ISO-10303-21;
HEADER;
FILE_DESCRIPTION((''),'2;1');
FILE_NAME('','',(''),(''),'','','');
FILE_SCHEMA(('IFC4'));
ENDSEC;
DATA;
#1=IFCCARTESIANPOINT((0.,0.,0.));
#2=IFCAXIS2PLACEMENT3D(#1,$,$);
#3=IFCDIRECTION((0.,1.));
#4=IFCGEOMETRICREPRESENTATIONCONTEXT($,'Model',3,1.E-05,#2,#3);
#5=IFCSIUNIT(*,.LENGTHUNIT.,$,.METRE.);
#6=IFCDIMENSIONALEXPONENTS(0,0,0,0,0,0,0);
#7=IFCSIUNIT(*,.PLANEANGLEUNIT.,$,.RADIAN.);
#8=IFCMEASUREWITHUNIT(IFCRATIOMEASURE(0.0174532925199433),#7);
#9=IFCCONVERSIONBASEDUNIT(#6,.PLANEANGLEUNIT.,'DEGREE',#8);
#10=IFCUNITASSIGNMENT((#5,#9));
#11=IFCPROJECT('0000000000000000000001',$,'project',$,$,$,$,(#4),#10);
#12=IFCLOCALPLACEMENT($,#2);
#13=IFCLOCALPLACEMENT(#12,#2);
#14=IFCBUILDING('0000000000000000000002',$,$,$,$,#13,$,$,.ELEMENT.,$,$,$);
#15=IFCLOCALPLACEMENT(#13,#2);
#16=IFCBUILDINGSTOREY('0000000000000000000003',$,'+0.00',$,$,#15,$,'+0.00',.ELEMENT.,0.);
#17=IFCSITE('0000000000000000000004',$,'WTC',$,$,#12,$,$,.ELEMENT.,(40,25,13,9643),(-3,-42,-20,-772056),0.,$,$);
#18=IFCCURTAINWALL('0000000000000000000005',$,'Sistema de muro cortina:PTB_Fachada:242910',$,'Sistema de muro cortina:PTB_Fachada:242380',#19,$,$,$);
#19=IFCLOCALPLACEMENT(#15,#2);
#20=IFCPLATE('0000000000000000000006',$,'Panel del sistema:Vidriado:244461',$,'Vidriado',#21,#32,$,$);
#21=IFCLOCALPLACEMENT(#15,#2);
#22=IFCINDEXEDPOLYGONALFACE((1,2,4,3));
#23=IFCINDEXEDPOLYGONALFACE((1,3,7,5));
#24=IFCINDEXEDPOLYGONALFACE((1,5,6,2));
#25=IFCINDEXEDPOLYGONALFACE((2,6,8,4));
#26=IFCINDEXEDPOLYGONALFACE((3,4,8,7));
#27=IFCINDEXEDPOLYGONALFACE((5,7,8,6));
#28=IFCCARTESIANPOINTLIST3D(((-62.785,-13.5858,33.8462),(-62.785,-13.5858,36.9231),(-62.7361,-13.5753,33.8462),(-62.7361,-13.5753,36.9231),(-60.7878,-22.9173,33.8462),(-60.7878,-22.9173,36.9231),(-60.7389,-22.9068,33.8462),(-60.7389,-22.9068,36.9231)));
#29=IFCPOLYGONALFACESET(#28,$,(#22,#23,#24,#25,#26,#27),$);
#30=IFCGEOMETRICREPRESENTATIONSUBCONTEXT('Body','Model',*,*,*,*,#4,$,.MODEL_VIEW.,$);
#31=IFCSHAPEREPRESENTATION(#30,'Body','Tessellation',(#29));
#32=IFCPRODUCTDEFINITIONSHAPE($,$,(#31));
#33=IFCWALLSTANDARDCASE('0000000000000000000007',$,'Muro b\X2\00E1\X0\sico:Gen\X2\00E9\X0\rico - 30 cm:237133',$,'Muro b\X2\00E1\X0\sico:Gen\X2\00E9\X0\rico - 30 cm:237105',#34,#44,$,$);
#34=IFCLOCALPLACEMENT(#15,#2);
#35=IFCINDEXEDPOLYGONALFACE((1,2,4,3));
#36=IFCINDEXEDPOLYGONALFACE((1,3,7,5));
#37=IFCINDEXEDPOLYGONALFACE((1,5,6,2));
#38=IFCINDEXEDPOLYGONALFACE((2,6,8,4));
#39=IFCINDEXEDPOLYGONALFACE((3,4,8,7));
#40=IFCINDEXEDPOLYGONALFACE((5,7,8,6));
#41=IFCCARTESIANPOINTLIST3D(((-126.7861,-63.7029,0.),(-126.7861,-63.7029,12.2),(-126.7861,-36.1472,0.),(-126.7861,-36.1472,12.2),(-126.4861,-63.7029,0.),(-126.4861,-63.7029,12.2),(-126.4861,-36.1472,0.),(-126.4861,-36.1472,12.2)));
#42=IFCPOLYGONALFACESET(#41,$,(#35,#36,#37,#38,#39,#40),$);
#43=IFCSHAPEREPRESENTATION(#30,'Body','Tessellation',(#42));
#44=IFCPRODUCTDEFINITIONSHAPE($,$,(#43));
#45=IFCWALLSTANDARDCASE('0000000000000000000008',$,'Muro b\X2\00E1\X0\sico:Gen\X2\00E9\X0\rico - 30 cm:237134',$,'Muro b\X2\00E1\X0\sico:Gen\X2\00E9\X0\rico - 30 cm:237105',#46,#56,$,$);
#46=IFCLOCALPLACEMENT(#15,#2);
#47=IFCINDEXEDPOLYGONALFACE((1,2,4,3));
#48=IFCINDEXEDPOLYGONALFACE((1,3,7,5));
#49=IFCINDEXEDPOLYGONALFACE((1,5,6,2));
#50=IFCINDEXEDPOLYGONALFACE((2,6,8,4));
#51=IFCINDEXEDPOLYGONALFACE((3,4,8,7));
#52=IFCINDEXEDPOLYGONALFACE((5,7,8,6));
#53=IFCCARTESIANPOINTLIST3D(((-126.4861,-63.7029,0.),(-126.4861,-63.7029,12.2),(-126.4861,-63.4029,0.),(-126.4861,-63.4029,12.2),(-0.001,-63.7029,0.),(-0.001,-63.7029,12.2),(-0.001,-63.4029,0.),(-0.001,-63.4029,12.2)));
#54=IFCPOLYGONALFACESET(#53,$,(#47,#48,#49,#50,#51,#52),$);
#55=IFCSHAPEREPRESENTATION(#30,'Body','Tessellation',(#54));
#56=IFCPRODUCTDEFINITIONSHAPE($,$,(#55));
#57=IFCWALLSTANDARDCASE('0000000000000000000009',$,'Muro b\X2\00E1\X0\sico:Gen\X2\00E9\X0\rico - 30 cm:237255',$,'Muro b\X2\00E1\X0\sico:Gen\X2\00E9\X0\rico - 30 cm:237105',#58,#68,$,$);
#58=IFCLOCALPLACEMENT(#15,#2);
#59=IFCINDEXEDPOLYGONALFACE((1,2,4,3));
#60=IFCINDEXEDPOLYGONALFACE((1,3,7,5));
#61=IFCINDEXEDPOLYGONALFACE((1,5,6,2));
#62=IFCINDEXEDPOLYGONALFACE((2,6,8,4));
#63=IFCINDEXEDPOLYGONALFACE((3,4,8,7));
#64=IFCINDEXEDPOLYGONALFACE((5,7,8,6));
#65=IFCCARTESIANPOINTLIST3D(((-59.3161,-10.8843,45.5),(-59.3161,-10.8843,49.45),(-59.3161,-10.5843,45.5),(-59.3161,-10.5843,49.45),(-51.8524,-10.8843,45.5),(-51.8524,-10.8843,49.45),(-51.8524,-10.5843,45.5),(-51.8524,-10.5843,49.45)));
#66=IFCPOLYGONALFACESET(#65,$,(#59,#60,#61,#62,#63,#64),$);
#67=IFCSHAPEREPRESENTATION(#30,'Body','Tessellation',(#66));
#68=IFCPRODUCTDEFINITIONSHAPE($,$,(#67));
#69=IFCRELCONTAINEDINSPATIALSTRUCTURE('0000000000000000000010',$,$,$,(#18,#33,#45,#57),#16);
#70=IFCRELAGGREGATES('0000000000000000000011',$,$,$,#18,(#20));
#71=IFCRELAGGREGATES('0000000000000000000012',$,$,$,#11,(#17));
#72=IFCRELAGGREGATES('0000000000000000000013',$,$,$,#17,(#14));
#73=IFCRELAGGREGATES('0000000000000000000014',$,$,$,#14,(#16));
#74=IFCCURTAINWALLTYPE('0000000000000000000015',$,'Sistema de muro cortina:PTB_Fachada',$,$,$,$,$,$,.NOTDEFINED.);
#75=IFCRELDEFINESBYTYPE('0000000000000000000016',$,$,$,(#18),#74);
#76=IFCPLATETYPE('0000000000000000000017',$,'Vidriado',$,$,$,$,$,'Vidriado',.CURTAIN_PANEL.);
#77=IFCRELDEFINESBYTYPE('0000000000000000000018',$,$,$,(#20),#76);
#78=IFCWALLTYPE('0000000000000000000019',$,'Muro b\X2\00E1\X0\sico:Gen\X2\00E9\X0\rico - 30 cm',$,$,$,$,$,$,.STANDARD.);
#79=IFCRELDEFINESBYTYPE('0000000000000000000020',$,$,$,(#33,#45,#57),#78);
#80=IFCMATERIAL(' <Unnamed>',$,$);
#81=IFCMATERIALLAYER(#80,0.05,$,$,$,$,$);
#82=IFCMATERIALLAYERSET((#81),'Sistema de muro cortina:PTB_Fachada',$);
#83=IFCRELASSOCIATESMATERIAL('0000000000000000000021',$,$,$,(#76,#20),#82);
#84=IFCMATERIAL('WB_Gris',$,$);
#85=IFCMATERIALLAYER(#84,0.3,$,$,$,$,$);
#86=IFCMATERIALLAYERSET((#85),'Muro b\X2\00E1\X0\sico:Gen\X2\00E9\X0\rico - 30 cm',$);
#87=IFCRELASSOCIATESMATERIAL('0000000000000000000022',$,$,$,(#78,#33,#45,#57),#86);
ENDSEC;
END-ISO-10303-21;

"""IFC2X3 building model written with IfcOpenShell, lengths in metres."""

from ifc_helpers import new_model, entity, si_unit, converted_unit, direction, frame, frame_2d, origin, origin_2d_with_axis, place, context, subcontext, project, spatial, polyline, rectangle, extrude, clip, bounded_halfspace, source, transform, mapped, material, layer, layer_set, layer_usage, type_object, type_shapes, element, aggregate, save


model = new_model("IFC2X3")

# Units and contexts
model_context = context("Model", 3, precision=1e-05, world=origin(), true_north=direction((0.0, 1.0)))
body_context = subcontext(model_context, "Body", "Model", "MODEL_VIEW")
ifc_project = project(units=[si_unit("LENGTHUNIT", "METRE"), converted_unit("PLANEANGLEUNIT", "DEGREE", entity("IfcRatioMeasure", 0.0174532925199433), si_unit("PLANEANGLEUNIT", "RADIAN"), dimensions=[0, 0, 0, 0, 0, 0, 0])], contexts=[model_context])

# Site, building, storey
site_placement = place(None, origin())
site = spatial("IfcSite", under=ifc_project, at=site_placement, Name="WTC", CompositionType="ELEMENT", RefLatitude=(40, 25, 13, 9643), RefLongitude=(-3, -42, -20, -772056), RefElevation=0.0)
building_placement = place(site_placement, origin())
building = spatial("IfcBuilding", under=site, at=building_placement, CompositionType="ELEMENT")
storey_placement = place(building_placement, origin())
storey = spatial("IfcBuildingStorey", under=building, at=storey_placement, Name="+0.00", LongName="+0.00", CompositionType="ELEMENT", Elevation=0.0)

# Curtain wall, plate
curtain_wall_type = type_object("IfcCurtainWallType", Name="Sistema de muro cortina:PTB_Fachada", PredefinedType="NOTDEFINED")
curtain_wall_placement = place(storey_placement, origin())
curtain_wall = element("IfcCurtainWall", 1, at=curtain_wall_placement, inside=storey, type_object=curtain_wall_type, Name="Sistema de muro cortina:PTB_Fachada:242910", ObjectType="Sistema de muro cortina:PTB_Fachada:242380")
ifc_material_1 = material(Name=" <Unnamed>")
ifc_layer_1 = layer(ifc_material_1, 0.05)
ifc_layer_set_1 = layer_set([ifc_layer_1], Name="Sistema de muro cortina:PTB_Fachada")
plate_type_1 = type_object("IfcPlateType", Name="Vidriado", ElementType="Vidriado", PredefinedType="CURTAIN_PANEL", material=ifc_layer_set_1)
shared_shape_1 = source(origin(), body_context, "Body", "SweptSolid", [
    extrude(rectangle(XDim=0.05, YDim=9.5428, at=origin_2d_with_axis()), frame((0.0, 0.0, 0.0), z_axis=(0.0, 0.0, 1.0), x_axis=(0.0, 1.0, 0.0)), (0.0, 0.0, 1.0), 3.0769),
])
type_shapes(plate_type_1, [shared_shape_1])
ifc_layer_usage_1 = layer_usage(ifc_layer_set_1, "AXIS3", "POSITIVE", 0.0)
plate_1_placement = place(curtain_wall_placement, frame((-61.762, -18.2463, 33.8462), z_axis=(0.0, 0.0, 1.0), x_axis=(0.209296, -0.977852, 0.0)))
plate_1 = element("IfcPlate", 2, at=plate_1_placement, type_object=plate_type_1, material=ifc_layer_usage_1, Name="Panel del sistema:Vidriado:244461", ObjectType="Vidriado", context=body_context, shape_type="MappedRepresentation", body=[
    mapped(shared_shape_1, transform((0.0, 0.0, 0.0), scale=1.0)),
])
aggregate(curtain_wall, [plate_1])

# Walls
ifc_material_2 = material(Name="WB_Gris")
ifc_layer_2 = layer(ifc_material_2, 0.3)
ifc_layer_set_2 = layer_set([ifc_layer_2], Name="Muro básico:Genérico - 30 cm")
ifc_layer_usage_2 = layer_usage(ifc_layer_set_2, "AXIS2", "POSITIVE", -0.15)
wall_type = type_object("IfcWallType", Name="Muro básico:Genérico - 30 cm", PredefinedType="STANDARD", material=ifc_layer_set_2)
wall_1_placement = place(storey_placement, frame((-126.6361, -36.1472, 0.0), z_axis=(0.0, 0.0, 1.0), x_axis=(0.0, -1.0, 0.0)))
element("IfcWallStandardCase", 3, at=wall_1_placement, inside=storey, type_object=wall_type, material=ifc_layer_usage_2, Name="Muro básico:Genérico - 30 cm:237133", ObjectType="Muro básico:Genérico - 30 cm:237105", context=body_context, shape_type="Clipping", body=[
    clip(extrude(rectangle(XDim=27.5557, YDim=0.3, at=frame_2d((13.7778, 0.0), x_axis=(-1.0, 0.0))), origin(), (0.0, 0.0, 1.0), 12.2), bounded_halfspace(frame((0.0, -0.15, 12.2)), False, frame((0.0, -0.15, 12.2)), polyline([(0.0, 0.0), (27.5557, 0.0), (27.5557, 0.3), (0.0, 0.3), (0.0, 0.0)]))),
])
ifc_layer_usage_3 = layer_usage(ifc_layer_set_2, "AXIS2", "POSITIVE", -0.15)
wall_2_placement = place(storey_placement, frame((-126.4861, -63.5529, 0.0)))
element("IfcWallStandardCase", 4, at=wall_2_placement, inside=storey, type_object=wall_type, material=ifc_layer_usage_3, Name="Muro básico:Genérico - 30 cm:237134", ObjectType="Muro básico:Genérico - 30 cm:237105", context=body_context, shape_type="Clipping", body=[
    clip(extrude(rectangle(XDim=126.4851, YDim=0.3, at=frame_2d((63.2426, 0.0), x_axis=(-1.0, 0.0))), origin(), (0.0, 0.0, 1.0), 12.2), bounded_halfspace(frame((0.0, -0.15, 12.2), z_axis=(0.0, 0.0, 1.0), x_axis=(0.0, -1.0, 0.0)), False, frame((0.0, -0.15, 12.2), z_axis=(0.0, 0.0, 1.0), x_axis=(0.0, -1.0, 0.0)), polyline([(0.0, 0.0), (0.0, 126.4851), (-0.3, 126.4851), (-0.3, 0.0), (0.0, 0.0)]))),
])
ifc_layer_usage_4 = layer_usage(ifc_layer_set_2, "AXIS2", "NEGATIVE", 0.15)
wall_3_placement = place(storey_placement, frame((-59.3161, -10.7343, 45.5)))
element("IfcWallStandardCase", 5, at=wall_3_placement, inside=storey, type_object=wall_type, material=ifc_layer_usage_4, Name="Muro básico:Genérico - 30 cm:237255", ObjectType="Muro básico:Genérico - 30 cm:237105", context=body_context, shape_type="Clipping", body=[
    clip(extrude(rectangle(XDim=7.4637, YDim=0.3, at=frame_2d((3.7319, 0.0), x_axis=(-1.0, 0.0))), origin(), (0.0, 0.0, 1.0), 3.95), bounded_halfspace(frame((0.0, -0.15, 3.95), z_axis=(0.0, 0.0, 1.0), x_axis=(-1.0, 0.0, 0.0)), False, frame((0.0, -0.15, 3.95), z_axis=(0.0, 0.0, 1.0), x_axis=(-1.0, 0.0, 0.0)), polyline([(0.0, 0.0), (-7.4637, 0.0), (-7.4637, -0.3), (-7.1637, -0.3), (0.0, -0.3), (0.0, 0.0)]))),
])

save(model, "model.ifc")
